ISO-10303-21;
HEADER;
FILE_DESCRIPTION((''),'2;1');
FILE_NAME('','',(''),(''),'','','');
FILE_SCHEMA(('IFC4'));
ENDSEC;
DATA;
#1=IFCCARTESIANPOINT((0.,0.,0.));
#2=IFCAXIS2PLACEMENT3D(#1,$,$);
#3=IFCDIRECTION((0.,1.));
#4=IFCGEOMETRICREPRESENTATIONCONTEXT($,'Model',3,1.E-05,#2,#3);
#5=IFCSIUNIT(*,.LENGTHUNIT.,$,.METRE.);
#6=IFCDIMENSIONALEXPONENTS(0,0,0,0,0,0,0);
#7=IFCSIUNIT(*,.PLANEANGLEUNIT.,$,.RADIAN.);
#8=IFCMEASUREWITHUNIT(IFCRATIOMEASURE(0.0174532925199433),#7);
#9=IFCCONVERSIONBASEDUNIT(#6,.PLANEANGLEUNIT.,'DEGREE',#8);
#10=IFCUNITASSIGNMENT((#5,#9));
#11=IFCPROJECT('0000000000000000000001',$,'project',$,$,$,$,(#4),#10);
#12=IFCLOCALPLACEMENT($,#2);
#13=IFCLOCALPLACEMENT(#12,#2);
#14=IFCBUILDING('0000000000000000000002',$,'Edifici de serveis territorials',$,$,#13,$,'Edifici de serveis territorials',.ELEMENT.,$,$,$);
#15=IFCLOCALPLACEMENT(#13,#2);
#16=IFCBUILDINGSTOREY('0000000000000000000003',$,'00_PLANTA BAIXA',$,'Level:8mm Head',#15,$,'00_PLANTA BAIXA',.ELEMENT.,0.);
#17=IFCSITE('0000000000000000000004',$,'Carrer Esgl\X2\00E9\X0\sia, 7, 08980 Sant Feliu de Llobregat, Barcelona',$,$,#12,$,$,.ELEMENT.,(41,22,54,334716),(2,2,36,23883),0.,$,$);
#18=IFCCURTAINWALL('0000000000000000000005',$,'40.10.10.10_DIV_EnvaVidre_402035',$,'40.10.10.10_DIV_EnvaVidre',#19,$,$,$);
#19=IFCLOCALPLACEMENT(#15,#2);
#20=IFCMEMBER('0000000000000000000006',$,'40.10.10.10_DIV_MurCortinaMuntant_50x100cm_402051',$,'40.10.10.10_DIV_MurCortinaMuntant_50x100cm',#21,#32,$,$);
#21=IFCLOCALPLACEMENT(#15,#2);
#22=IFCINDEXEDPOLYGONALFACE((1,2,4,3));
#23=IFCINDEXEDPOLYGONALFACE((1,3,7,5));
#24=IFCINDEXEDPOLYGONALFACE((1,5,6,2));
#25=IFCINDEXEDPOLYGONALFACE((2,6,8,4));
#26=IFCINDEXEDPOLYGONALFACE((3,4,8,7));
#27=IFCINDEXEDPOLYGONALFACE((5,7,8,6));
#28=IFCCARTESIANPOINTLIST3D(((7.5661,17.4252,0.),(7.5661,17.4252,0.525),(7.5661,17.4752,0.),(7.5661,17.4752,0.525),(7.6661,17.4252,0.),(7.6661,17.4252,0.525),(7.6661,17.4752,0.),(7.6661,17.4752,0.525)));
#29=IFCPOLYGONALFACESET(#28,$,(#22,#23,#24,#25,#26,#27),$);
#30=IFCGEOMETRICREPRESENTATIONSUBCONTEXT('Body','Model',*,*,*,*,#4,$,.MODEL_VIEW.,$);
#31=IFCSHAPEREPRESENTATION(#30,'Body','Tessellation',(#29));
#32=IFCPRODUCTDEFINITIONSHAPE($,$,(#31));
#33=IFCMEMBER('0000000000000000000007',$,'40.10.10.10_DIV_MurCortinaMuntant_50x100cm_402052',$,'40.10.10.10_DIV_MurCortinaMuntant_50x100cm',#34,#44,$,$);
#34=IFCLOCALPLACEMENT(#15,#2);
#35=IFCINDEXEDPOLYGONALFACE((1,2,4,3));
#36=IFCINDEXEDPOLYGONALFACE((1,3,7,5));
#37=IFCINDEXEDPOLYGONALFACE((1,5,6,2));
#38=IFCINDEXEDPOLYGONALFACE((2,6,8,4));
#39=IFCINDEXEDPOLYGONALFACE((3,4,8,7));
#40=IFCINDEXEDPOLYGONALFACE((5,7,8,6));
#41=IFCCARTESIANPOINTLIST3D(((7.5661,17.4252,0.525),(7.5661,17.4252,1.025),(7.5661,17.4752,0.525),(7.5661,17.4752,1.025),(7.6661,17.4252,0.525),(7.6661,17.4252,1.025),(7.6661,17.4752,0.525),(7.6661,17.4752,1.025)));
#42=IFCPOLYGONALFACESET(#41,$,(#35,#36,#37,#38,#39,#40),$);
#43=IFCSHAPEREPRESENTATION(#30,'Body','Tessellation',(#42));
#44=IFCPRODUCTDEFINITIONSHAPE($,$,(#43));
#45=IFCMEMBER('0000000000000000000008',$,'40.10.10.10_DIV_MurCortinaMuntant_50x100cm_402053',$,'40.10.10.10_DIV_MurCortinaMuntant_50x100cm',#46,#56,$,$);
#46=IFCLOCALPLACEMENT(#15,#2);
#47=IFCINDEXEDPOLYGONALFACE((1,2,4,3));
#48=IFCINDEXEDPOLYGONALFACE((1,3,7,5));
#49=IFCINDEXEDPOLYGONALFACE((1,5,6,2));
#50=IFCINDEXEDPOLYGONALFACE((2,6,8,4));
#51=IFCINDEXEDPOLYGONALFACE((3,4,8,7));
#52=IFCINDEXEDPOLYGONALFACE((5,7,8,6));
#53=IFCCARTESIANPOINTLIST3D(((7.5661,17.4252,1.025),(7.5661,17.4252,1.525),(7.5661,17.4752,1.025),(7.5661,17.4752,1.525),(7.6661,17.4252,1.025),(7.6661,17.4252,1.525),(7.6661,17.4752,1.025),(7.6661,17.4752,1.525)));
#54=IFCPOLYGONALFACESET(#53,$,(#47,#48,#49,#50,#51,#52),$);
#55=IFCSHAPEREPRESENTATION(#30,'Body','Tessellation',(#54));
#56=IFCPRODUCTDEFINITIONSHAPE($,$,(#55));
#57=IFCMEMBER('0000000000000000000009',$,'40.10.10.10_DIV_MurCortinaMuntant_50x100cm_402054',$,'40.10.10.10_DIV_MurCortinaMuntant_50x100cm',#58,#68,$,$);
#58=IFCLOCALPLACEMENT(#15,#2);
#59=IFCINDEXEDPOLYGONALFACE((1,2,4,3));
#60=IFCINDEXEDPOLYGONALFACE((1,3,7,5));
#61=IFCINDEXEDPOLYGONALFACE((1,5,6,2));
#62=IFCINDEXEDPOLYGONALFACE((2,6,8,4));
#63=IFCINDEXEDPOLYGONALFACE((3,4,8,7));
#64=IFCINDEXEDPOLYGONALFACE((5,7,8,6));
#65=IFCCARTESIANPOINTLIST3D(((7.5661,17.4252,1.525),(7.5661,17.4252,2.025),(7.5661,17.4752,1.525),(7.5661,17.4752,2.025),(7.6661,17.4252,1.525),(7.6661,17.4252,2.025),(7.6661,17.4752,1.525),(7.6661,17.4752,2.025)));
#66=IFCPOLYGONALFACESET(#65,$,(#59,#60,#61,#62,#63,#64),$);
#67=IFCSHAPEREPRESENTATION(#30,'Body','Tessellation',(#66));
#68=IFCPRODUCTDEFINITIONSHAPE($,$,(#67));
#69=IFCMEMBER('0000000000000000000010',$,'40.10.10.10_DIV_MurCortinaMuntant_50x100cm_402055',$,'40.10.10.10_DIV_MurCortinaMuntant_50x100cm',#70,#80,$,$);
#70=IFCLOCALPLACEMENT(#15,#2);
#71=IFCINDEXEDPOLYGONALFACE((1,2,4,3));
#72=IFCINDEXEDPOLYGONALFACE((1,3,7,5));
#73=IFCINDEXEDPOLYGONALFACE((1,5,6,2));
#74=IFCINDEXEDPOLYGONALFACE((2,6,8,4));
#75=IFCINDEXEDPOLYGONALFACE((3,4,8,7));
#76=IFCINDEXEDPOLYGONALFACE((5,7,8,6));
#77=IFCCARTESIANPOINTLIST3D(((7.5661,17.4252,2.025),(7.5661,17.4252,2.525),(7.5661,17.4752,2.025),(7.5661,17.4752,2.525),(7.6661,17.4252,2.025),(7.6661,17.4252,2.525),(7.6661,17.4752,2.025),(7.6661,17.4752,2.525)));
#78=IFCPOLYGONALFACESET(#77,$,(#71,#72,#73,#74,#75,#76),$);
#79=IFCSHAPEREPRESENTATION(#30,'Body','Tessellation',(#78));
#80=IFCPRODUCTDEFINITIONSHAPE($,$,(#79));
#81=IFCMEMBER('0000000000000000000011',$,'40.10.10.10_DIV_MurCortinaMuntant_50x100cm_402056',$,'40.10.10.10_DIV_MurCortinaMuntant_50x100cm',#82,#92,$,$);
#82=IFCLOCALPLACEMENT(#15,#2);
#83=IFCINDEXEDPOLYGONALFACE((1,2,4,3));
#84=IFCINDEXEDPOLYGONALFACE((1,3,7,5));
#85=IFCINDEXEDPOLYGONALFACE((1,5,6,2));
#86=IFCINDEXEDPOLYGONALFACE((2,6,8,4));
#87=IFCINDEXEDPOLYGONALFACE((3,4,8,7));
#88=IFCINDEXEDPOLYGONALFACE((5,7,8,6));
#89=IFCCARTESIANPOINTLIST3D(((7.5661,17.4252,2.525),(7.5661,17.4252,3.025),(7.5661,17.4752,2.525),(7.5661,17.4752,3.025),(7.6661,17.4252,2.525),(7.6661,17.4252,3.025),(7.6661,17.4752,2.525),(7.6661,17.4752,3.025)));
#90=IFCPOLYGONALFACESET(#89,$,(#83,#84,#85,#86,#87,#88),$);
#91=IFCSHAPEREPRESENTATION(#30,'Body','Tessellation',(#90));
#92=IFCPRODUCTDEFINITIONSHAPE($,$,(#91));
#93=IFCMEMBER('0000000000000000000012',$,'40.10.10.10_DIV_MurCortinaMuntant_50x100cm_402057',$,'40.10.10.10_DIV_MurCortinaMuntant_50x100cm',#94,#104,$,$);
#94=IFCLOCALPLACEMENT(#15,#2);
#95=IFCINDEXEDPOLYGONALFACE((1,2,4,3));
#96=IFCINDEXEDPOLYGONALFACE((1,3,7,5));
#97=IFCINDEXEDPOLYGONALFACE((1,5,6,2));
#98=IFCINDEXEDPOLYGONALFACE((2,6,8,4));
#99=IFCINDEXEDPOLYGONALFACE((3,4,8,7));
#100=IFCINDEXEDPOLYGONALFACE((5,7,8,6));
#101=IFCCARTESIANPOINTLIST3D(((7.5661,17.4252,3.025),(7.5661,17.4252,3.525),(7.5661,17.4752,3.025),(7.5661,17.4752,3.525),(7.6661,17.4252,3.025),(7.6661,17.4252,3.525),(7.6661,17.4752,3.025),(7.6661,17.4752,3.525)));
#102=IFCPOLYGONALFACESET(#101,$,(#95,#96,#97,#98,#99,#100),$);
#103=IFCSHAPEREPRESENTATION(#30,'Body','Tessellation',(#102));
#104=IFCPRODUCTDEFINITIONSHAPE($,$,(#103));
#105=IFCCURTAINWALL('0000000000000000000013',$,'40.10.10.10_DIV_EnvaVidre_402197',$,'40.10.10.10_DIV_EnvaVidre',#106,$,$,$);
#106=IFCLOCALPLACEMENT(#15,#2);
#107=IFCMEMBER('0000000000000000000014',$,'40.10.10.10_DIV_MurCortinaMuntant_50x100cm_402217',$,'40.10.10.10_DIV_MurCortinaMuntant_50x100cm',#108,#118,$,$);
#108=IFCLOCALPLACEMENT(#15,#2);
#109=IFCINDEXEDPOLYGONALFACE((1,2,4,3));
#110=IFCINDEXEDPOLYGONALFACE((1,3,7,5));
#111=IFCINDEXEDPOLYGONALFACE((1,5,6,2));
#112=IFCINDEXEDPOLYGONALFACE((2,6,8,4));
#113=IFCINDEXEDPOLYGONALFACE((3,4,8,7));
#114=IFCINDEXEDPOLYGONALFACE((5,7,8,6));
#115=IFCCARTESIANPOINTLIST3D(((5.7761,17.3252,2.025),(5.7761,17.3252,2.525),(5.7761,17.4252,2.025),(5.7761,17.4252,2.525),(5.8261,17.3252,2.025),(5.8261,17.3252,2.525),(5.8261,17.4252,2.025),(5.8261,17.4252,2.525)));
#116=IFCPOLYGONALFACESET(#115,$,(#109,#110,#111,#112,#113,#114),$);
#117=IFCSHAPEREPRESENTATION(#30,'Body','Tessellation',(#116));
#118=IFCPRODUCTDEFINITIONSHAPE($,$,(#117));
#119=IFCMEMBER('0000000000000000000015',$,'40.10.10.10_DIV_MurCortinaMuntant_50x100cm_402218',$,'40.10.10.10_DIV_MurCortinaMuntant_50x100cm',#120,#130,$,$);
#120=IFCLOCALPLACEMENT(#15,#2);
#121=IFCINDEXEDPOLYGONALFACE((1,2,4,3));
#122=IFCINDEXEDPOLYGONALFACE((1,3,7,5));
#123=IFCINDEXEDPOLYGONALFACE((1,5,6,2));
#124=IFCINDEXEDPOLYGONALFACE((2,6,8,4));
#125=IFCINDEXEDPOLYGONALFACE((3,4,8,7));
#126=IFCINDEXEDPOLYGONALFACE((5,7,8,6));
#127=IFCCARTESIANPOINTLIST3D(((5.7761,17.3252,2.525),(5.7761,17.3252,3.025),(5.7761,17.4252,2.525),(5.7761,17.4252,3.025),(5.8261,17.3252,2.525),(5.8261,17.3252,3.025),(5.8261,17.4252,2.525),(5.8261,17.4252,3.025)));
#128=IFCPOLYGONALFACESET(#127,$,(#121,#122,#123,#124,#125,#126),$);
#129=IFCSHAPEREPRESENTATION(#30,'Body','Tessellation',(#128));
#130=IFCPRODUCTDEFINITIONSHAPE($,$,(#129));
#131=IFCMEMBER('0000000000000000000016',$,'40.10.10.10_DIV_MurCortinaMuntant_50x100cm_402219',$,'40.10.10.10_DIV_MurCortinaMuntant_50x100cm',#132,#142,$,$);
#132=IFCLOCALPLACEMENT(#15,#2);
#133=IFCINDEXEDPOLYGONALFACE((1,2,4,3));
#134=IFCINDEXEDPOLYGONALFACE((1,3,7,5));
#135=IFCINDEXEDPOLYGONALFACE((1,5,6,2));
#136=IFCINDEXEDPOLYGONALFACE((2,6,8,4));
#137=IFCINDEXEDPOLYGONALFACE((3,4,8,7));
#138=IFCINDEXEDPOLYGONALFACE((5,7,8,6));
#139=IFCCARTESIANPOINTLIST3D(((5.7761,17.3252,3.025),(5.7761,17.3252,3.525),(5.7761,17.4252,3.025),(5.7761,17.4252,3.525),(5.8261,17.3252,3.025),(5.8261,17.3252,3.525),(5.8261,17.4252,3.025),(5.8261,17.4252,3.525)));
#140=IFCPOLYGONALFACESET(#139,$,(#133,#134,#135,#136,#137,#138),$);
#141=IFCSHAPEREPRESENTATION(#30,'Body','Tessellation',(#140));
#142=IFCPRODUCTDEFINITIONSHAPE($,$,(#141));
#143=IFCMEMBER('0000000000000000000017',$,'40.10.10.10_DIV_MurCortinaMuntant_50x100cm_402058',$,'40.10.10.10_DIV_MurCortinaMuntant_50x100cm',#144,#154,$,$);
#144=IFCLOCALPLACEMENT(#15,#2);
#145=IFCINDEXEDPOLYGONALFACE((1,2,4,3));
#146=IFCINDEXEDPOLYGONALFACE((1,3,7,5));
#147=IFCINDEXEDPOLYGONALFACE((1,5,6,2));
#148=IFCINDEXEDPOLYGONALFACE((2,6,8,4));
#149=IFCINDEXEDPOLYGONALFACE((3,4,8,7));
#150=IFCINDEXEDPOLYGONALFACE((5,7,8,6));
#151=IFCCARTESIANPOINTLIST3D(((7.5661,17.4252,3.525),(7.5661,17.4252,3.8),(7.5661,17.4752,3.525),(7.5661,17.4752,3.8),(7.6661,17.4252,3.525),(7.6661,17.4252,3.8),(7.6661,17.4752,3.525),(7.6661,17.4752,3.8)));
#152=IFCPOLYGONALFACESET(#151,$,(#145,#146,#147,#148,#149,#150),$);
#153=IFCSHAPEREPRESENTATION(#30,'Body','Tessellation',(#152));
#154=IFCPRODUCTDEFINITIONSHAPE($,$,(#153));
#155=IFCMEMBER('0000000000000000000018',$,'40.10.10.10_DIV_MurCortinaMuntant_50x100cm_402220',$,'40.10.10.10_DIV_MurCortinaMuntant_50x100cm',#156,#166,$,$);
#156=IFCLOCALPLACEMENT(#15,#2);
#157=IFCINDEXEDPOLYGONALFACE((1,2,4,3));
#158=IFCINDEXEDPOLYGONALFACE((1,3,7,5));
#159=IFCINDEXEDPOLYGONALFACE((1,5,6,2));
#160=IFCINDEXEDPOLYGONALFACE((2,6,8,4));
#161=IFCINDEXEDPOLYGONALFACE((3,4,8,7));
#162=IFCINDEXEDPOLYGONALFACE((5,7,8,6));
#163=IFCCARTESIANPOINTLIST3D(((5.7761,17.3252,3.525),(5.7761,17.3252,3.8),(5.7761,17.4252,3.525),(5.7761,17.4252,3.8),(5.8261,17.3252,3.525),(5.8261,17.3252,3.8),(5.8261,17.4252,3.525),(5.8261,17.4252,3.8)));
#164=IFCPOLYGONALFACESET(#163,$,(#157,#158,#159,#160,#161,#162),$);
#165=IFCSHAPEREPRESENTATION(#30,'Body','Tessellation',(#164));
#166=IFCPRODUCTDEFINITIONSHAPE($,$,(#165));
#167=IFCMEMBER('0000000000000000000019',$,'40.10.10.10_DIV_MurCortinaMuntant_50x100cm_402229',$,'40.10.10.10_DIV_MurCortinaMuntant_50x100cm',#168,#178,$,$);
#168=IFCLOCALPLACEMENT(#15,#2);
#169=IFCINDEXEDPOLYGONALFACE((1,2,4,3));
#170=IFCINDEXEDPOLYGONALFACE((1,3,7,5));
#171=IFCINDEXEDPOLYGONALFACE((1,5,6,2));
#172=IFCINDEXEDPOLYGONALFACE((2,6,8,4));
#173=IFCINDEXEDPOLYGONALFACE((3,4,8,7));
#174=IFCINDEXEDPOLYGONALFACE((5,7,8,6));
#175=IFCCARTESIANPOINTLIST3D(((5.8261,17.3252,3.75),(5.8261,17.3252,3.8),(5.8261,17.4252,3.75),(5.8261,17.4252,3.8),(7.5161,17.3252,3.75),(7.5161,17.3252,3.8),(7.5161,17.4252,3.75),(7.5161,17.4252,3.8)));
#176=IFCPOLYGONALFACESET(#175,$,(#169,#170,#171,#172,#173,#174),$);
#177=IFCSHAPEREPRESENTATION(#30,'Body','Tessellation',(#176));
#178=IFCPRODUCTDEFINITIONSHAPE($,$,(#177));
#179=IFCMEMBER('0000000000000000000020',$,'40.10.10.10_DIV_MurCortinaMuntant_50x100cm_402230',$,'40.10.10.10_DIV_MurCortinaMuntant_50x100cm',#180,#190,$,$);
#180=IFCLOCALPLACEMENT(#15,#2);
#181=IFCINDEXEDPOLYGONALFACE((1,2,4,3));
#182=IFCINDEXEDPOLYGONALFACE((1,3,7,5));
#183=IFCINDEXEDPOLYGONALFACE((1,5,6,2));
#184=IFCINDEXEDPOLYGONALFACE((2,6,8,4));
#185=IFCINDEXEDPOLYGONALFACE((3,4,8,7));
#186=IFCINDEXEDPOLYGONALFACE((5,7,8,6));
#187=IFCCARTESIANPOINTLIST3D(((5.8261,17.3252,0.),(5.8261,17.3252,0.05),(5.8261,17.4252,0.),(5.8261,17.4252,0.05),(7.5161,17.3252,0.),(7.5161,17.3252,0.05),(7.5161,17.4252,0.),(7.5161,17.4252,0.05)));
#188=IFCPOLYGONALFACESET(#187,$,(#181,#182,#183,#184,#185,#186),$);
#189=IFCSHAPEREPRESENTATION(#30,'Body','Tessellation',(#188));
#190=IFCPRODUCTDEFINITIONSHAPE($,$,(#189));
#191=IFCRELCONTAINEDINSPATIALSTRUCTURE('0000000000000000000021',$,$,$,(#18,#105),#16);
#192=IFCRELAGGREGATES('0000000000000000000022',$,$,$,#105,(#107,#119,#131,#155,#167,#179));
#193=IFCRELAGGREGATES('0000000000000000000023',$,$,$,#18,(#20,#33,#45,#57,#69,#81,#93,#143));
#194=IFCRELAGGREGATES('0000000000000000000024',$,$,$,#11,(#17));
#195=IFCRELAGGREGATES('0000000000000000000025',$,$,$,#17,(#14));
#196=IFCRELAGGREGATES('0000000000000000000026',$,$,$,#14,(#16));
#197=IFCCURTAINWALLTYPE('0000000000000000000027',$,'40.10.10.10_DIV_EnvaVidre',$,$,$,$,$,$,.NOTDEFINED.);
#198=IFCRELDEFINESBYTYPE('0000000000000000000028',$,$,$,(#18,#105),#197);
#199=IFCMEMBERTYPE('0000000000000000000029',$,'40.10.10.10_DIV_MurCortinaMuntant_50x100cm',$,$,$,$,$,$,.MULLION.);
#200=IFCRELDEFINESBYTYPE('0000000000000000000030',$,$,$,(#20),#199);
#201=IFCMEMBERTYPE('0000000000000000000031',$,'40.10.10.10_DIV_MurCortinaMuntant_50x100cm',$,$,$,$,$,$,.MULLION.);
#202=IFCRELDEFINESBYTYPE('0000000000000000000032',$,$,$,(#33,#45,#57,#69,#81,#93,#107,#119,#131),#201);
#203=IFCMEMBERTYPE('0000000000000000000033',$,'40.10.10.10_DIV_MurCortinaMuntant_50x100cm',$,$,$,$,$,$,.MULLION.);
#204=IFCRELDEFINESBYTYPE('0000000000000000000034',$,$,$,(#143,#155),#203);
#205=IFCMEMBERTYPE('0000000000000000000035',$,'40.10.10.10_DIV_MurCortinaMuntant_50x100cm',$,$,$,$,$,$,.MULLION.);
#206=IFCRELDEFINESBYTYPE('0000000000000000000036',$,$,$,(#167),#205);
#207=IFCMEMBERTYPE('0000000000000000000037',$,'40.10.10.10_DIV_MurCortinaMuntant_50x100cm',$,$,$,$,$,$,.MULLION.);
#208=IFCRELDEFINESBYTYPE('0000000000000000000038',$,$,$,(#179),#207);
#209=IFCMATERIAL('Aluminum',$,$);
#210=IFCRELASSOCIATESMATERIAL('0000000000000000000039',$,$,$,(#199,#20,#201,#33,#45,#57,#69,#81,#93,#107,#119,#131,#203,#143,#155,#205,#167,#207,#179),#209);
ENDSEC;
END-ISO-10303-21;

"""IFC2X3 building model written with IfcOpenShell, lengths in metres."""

from ifc_helpers import new_model, entity, si_unit, converted_unit, direction, frame, origin, origin_2d_with_axis, place, context, subcontext, project, spatial, rectangle, extrude, source, transform, mapped, material, type_object, type_shapes, element, aggregate, save


model = new_model("IFC2X3")

# Units and contexts
model_context = context("Model", 3, precision=1e-05, world=origin(), true_north=direction((0.0, 1.0)))
body_context = subcontext(model_context, "Body", "Model", "MODEL_VIEW")
ifc_project = project(units=[si_unit("LENGTHUNIT", "METRE"), converted_unit("PLANEANGLEUNIT", "DEGREE", entity("IfcRatioMeasure", 0.0174532925199433), si_unit("PLANEANGLEUNIT", "RADIAN"), dimensions=[0, 0, 0, 0, 0, 0, 0])], contexts=[model_context])

# Site, building, storey
site_placement = place(None, origin())
site = spatial("IfcSite", under=ifc_project, at=site_placement, Name="Carrer Església, 7, 08980 Sant Feliu de Llobregat, Barcelona", CompositionType="ELEMENT", RefLatitude=(41, 22, 54, 334716), RefLongitude=(2, 2, 36, 23883), RefElevation=0.0)
building_placement = place(site_placement, origin())
building = spatial("IfcBuilding", under=site, at=building_placement, Name="Edifici de serveis territorials", LongName="Edifici de serveis territorials", CompositionType="ELEMENT")
storey_placement = place(building_placement, origin())
storey = spatial("IfcBuildingStorey", under=building, at=storey_placement, Name="00_PLANTA BAIXA", ObjectType="Level:8mm Head", LongName="00_PLANTA BAIXA", CompositionType="ELEMENT", Elevation=0.0)

# Curtain walls, members
curtain_wall_type = type_object("IfcCurtainWallType", Name="40.10.10.10_DIV_EnvaVidre", PredefinedType="NOTDEFINED")
curtain_wall_1_placement = place(storey_placement, origin())
curtain_wall_1 = element("IfcCurtainWall", 1, at=curtain_wall_1_placement, inside=storey, type_object=curtain_wall_type, Name="40.10.10.10_DIV_EnvaVidre_402035", ObjectType="40.10.10.10_DIV_EnvaVidre")
ifc_material_1 = material(Name="Aluminum")
member_type_1 = type_object("IfcMemberType", Name="40.10.10.10_DIV_MurCortinaMuntant_50x100cm", PredefinedType="MULLION", material=ifc_material_1)
shared_shape_1 = source(origin(), body_context, "Body", "SweptSolid", [
    extrude(rectangle(XDim=0.1, YDim=0.05, at=origin_2d_with_axis()), frame((-0.025, 0.0, -0.525), z_axis=(0.0, 0.0, 1.0), x_axis=(0.0, -1.0, 0.0)), (0.0, 0.0, 1.0), 0.525),
])
type_shapes(member_type_1, [shared_shape_1])
member_1_placement = place(storey_placement, frame((7.6161, 17.4252, 0.0), z_axis=(0.0, 0.0, -1.0), x_axis=(0.0, -1.0, 0.0)))
member_1 = element("IfcMember", 2, at=member_1_placement, type_object=member_type_1, material=ifc_material_1, Name="40.10.10.10_DIV_MurCortinaMuntant_50x100cm_402051", ObjectType="40.10.10.10_DIV_MurCortinaMuntant_50x100cm", context=body_context, shape_type="MappedRepresentation", body=[
    mapped(shared_shape_1, transform((0.0, 0.0, 0.0), scale=1.0)),
])
member_type_2 = type_object("IfcMemberType", Name="40.10.10.10_DIV_MurCortinaMuntant_50x100cm", PredefinedType="MULLION", material=ifc_material_1)
shared_shape_2 = source(origin(), body_context, "Body", "SweptSolid", [
    extrude(rectangle(XDim=0.1, YDim=0.05, at=origin_2d_with_axis()), frame((-0.025, 0.0, -0.5), z_axis=(0.0, 0.0, 1.0), x_axis=(0.0, -1.0, 0.0)), (0.0, 0.0, 1.0), 0.5),
])
type_shapes(member_type_2, [shared_shape_2])
member_2_placement = place(storey_placement, frame((7.6161, 17.4252, 0.525), z_axis=(0.0, 0.0, -1.0), x_axis=(0.0, -1.0, 0.0)))
member_2 = element("IfcMember", 3, at=member_2_placement, type_object=member_type_2, material=ifc_material_1, Name="40.10.10.10_DIV_MurCortinaMuntant_50x100cm_402052", ObjectType="40.10.10.10_DIV_MurCortinaMuntant_50x100cm", context=body_context, shape_type="MappedRepresentation", body=[
    mapped(shared_shape_2, transform((0.0, 0.0, 0.0), scale=1.0)),
])
member_3_placement = place(storey_placement, frame((7.6161, 17.4252, 1.025), z_axis=(0.0, 0.0, -1.0), x_axis=(0.0, -1.0, 0.0)))
member_3 = element("IfcMember", 4, at=member_3_placement, type_object=member_type_2, material=ifc_material_1, Name="40.10.10.10_DIV_MurCortinaMuntant_50x100cm_402053", ObjectType="40.10.10.10_DIV_MurCortinaMuntant_50x100cm", context=body_context, shape_type="MappedRepresentation", body=[
    mapped(shared_shape_2, transform((0.0, 0.0, 0.0), scale=1.0)),
])
member_4_placement = place(storey_placement, frame((7.6161, 17.4252, 1.525), z_axis=(0.0, 0.0, -1.0), x_axis=(0.0, -1.0, 0.0)))
member_4 = element("IfcMember", 5, at=member_4_placement, type_object=member_type_2, material=ifc_material_1, Name="40.10.10.10_DIV_MurCortinaMuntant_50x100cm_402054", ObjectType="40.10.10.10_DIV_MurCortinaMuntant_50x100cm", context=body_context, shape_type="MappedRepresentation", body=[
    mapped(shared_shape_2, transform((0.0, 0.0, 0.0), scale=1.0)),
])
member_5_placement = place(storey_placement, frame((7.6161, 17.4252, 2.025), z_axis=(0.0, 0.0, -1.0), x_axis=(0.0, -1.0, 0.0)))
member_5 = element("IfcMember", 6, at=member_5_placement, type_object=member_type_2, material=ifc_material_1, Name="40.10.10.10_DIV_MurCortinaMuntant_50x100cm_402055", ObjectType="40.10.10.10_DIV_MurCortinaMuntant_50x100cm", context=body_context, shape_type="MappedRepresentation", body=[
    mapped(shared_shape_2, transform((0.0, 0.0, 0.0), scale=1.0)),
])
member_6_placement = place(storey_placement, frame((7.6161, 17.4252, 2.525), z_axis=(0.0, 0.0, -1.0), x_axis=(0.0, -1.0, 0.0)))
member_6 = element("IfcMember", 7, at=member_6_placement, type_object=member_type_2, material=ifc_material_1, Name="40.10.10.10_DIV_MurCortinaMuntant_50x100cm_402056", ObjectType="40.10.10.10_DIV_MurCortinaMuntant_50x100cm", context=body_context, shape_type="MappedRepresentation", body=[
    mapped(shared_shape_2, transform((0.0, 0.0, 0.0), scale=1.0)),
])
member_7_placement = place(storey_placement, frame((7.6161, 17.4252, 3.025), z_axis=(0.0, 0.0, -1.0), x_axis=(0.0, -1.0, 0.0)))
member_7 = element("IfcMember", 8, at=member_7_placement, type_object=member_type_2, material=ifc_material_1, Name="40.10.10.10_DIV_MurCortinaMuntant_50x100cm_402057", ObjectType="40.10.10.10_DIV_MurCortinaMuntant_50x100cm", context=body_context, shape_type="MappedRepresentation", body=[
    mapped(shared_shape_2, transform((0.0, 0.0, 0.0), scale=1.0)),
])
curtain_wall_2_placement = place(storey_placement, origin())
curtain_wall_2 = element("IfcCurtainWall", 9, at=curtain_wall_2_placement, inside=storey, type_object=curtain_wall_type, Name="40.10.10.10_DIV_EnvaVidre_402197", ObjectType="40.10.10.10_DIV_EnvaVidre")
member_8_placement = place(storey_placement, frame((5.7761, 17.3752, 2.025), z_axis=(0.0, 0.0, -1.0), x_axis=(-1.0, 0.0, 0.0)))
member_8 = element("IfcMember", 10, at=member_8_placement, type_object=member_type_2, material=ifc_material_1, Name="40.10.10.10_DIV_MurCortinaMuntant_50x100cm_402217", ObjectType="40.10.10.10_DIV_MurCortinaMuntant_50x100cm", context=body_context, shape_type="MappedRepresentation", body=[
    mapped(shared_shape_2, transform((0.0, 0.0, 0.0), scale=1.0)),
])
member_9_placement = place(storey_placement, frame((5.7761, 17.3752, 2.525), z_axis=(0.0, 0.0, -1.0), x_axis=(-1.0, 0.0, 0.0)))
member_9 = element("IfcMember", 11, at=member_9_placement, type_object=member_type_2, material=ifc_material_1, Name="40.10.10.10_DIV_MurCortinaMuntant_50x100cm_402218", ObjectType="40.10.10.10_DIV_MurCortinaMuntant_50x100cm", context=body_context, shape_type="MappedRepresentation", body=[
    mapped(shared_shape_2, transform((0.0, 0.0, 0.0), scale=1.0)),
])
member_10_placement = place(storey_placement, frame((5.7761, 17.3752, 3.025), z_axis=(0.0, 0.0, -1.0), x_axis=(-1.0, 0.0, 0.0)))
member_10 = element("IfcMember", 12, at=member_10_placement, type_object=member_type_2, material=ifc_material_1, Name="40.10.10.10_DIV_MurCortinaMuntant_50x100cm_402219", ObjectType="40.10.10.10_DIV_MurCortinaMuntant_50x100cm", context=body_context, shape_type="MappedRepresentation", body=[
    mapped(shared_shape_2, transform((0.0, 0.0, 0.0), scale=1.0)),
])

# Members
member_type_3 = type_object("IfcMemberType", Name="40.10.10.10_DIV_MurCortinaMuntant_50x100cm", PredefinedType="MULLION", material=ifc_material_1)
shared_shape_3 = source(origin(), body_context, "Body", "SweptSolid", [
    extrude(rectangle(XDim=0.1, YDim=0.05, at=origin_2d_with_axis()), frame((-0.025, 0.0, -0.275), z_axis=(0.0, 0.0, 1.0), x_axis=(0.0, -1.0, 0.0)), (0.0, 0.0, 1.0), 0.275),
])
type_shapes(member_type_3, [shared_shape_3])
member_11_placement = place(storey_placement, frame((7.6161, 17.4252, 3.525), z_axis=(0.0, 0.0, -1.0), x_axis=(0.0, -1.0, 0.0)))
member_11 = element("IfcMember", 13, at=member_11_placement, type_object=member_type_3, material=ifc_material_1, Name="40.10.10.10_DIV_MurCortinaMuntant_50x100cm_402058", ObjectType="40.10.10.10_DIV_MurCortinaMuntant_50x100cm", context=body_context, shape_type="MappedRepresentation", body=[
    mapped(shared_shape_3, transform((0.0, 0.0, 0.0), scale=1.0)),
])
member_12_placement = place(storey_placement, frame((5.7761, 17.3752, 3.525), z_axis=(0.0, 0.0, -1.0), x_axis=(-1.0, 0.0, 0.0)))
member_12 = element("IfcMember", 14, at=member_12_placement, type_object=member_type_3, material=ifc_material_1, Name="40.10.10.10_DIV_MurCortinaMuntant_50x100cm_402220", ObjectType="40.10.10.10_DIV_MurCortinaMuntant_50x100cm", context=body_context, shape_type="MappedRepresentation", body=[
    mapped(shared_shape_3, transform((0.0, 0.0, 0.0), scale=1.0)),
])
member_type_4 = type_object("IfcMemberType", Name="40.10.10.10_DIV_MurCortinaMuntant_50x100cm", PredefinedType="MULLION", material=ifc_material_1)
shared_shape_4 = source(origin(), body_context, "Body", "SweptSolid", [
    extrude(rectangle(XDim=0.1, YDim=0.05, at=origin_2d_with_axis()), frame((-0.025, 0.0, -1.69), z_axis=(0.0, 0.0, 1.0), x_axis=(0.0, -1.0, 0.0)), (0.0, 0.0, 1.0), 1.69),
])
type_shapes(member_type_4, [shared_shape_4])
member_13_placement = place(storey_placement, frame((5.8261, 17.3752, 3.8), z_axis=(-1.0, 0.0, 0.0), x_axis=(0.0, 0.0, 1.0)))
member_13 = element("IfcMember", 15, at=member_13_placement, type_object=member_type_4, material=ifc_material_1, Name="40.10.10.10_DIV_MurCortinaMuntant_50x100cm_402229", ObjectType="40.10.10.10_DIV_MurCortinaMuntant_50x100cm", context=body_context, shape_type="MappedRepresentation", body=[
    mapped(shared_shape_4, transform((0.0, 0.0, 0.0), scale=1.0)),
])
member_type_5 = type_object("IfcMemberType", Name="40.10.10.10_DIV_MurCortinaMuntant_50x100cm", PredefinedType="MULLION", material=ifc_material_1)
shared_shape_5 = source(origin(), body_context, "Body", "SweptSolid", [
    extrude(rectangle(XDim=0.1, YDim=0.05, at=origin_2d_with_axis()), frame((-0.025, 0.0, -1.69), z_axis=(0.0, 0.0, 1.0), x_axis=(0.0, -1.0, 0.0)), (0.0, 0.0, 1.0), 1.69),
])
type_shapes(member_type_5, [shared_shape_5])
member_14_placement = place(storey_placement, frame((7.5161, 17.3752, 0.0), z_axis=(1.0, 0.0, 0.0), x_axis=(0.0, 0.0, -1.0)))
member_14 = element("IfcMember", 16, at=member_14_placement, type_object=member_type_5, material=ifc_material_1, Name="40.10.10.10_DIV_MurCortinaMuntant_50x100cm_402230", ObjectType="40.10.10.10_DIV_MurCortinaMuntant_50x100cm", context=body_context, shape_type="MappedRepresentation", body=[
    mapped(shared_shape_5, transform((0.0, 0.0, 0.0), scale=1.0)),
])
aggregate(curtain_wall_2, [member_8, member_9, member_10, member_12, member_13, member_14])

aggregate(curtain_wall_1, [member_1, member_2, member_3, member_4, member_5, member_6, member_7, member_11])

save(model, "model.ifc")
